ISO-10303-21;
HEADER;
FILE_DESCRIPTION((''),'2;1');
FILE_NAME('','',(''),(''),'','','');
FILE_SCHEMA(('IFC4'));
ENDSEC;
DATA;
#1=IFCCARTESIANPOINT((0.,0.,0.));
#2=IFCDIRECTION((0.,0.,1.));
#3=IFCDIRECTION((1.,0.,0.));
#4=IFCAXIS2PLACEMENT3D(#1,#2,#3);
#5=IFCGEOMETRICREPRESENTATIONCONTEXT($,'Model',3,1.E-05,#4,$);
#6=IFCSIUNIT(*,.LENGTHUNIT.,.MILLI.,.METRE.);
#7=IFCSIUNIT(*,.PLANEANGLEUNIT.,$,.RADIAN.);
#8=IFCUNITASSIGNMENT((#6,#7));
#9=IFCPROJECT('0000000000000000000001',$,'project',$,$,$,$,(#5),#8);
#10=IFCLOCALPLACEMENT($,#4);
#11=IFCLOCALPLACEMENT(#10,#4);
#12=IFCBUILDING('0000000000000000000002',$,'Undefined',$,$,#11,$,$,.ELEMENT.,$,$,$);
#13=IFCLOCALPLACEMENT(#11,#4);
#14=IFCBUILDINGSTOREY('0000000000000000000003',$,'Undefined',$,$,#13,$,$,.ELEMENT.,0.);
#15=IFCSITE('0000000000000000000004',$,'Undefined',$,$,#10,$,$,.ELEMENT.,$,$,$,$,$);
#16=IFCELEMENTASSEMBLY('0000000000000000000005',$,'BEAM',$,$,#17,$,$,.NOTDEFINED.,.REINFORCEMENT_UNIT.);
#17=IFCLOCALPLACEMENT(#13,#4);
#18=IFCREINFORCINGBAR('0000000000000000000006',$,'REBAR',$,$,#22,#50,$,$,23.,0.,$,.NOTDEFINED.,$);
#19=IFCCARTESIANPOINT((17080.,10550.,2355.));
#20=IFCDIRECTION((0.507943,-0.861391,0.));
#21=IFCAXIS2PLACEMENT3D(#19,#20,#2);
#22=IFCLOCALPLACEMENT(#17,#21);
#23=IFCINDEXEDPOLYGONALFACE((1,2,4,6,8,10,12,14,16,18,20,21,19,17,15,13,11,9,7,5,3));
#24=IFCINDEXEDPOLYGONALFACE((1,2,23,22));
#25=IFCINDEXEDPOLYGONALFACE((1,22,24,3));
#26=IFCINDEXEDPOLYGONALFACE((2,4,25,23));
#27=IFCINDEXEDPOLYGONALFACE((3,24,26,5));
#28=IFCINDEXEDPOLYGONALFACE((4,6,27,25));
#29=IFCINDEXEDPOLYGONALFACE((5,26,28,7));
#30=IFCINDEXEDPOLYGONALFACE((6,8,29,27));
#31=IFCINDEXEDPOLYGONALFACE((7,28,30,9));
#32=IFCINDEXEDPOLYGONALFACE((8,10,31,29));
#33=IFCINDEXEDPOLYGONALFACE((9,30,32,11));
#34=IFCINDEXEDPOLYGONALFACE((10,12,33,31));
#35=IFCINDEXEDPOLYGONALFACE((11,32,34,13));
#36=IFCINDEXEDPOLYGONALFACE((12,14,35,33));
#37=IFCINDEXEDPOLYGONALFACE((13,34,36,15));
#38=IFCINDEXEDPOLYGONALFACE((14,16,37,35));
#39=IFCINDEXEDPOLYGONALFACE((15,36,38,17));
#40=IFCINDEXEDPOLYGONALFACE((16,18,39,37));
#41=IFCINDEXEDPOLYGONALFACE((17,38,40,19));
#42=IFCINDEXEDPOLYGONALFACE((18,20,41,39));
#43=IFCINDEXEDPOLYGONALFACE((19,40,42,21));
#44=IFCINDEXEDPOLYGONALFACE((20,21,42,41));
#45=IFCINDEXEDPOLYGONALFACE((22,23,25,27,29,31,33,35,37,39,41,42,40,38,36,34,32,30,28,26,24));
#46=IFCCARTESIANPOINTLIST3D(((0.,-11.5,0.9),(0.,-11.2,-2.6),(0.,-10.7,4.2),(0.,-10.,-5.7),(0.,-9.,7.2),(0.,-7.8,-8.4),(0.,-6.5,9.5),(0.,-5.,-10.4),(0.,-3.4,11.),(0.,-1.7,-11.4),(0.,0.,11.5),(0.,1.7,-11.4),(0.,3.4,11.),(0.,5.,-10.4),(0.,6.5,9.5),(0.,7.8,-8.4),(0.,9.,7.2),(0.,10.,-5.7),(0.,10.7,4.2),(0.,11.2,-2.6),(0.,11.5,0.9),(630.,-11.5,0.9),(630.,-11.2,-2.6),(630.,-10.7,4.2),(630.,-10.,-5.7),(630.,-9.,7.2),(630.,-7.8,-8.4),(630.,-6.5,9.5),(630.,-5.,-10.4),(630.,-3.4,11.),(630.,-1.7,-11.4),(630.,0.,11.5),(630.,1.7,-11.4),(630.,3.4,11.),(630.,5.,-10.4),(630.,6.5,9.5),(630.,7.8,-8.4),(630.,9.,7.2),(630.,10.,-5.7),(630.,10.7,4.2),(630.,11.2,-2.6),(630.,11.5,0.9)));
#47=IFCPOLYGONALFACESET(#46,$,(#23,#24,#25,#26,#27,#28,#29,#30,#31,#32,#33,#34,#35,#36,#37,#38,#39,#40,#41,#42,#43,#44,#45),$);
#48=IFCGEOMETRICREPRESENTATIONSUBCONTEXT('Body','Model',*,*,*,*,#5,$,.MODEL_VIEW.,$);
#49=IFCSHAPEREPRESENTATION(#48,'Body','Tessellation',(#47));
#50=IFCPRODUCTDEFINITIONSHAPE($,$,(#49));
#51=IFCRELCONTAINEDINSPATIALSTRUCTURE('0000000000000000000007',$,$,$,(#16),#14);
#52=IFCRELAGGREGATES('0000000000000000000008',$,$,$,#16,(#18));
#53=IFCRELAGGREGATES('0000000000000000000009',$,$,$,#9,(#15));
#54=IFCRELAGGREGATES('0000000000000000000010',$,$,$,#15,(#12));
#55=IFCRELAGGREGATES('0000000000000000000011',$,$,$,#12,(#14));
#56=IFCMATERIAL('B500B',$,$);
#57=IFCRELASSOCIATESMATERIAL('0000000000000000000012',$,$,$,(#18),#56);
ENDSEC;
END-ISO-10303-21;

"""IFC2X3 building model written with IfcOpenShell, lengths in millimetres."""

from ifc_helpers import new_model, entity, si_unit, frame, origin_with_axes, place, context, subcontext, project, spatial, source, transform, mapped, material, element, aggregate, save


model = new_model("IFC2X3")

# Units and contexts
model_context = context("Model", 3, precision=1e-05, world=origin_with_axes())
body_context = subcontext(model_context, "Body", "Model", "MODEL_VIEW")
ifc_project = project(units=[si_unit("LENGTHUNIT", "METRE", prefix="MILLI"), si_unit("PLANEANGLEUNIT", "RADIAN")], contexts=[model_context])

# Site, building, storey
site_placement = place(None, origin_with_axes())
site = spatial("IfcSite", under=ifc_project, at=site_placement, Name="Undefined", CompositionType="ELEMENT")
building_placement = place(site_placement, origin_with_axes())
building = spatial("IfcBuilding", under=site, at=building_placement, Name="Undefined", CompositionType="ELEMENT")
storey_placement = place(building_placement, origin_with_axes())
storey = spatial("IfcBuildingStorey", under=building, at=storey_placement, Name="Undefined", CompositionType="ELEMENT", Elevation=0.0)

# Element assembly
assembly_1_placement = place(storey_placement, origin_with_axes())
assembly_1 = element("IfcElementAssembly", 1, at=assembly_1_placement, inside=storey, Name="BEAM", AssemblyPlace="NOTDEFINED", PredefinedType="REINFORCEMENT_UNIT")

# Shared definitions
ifc_material_1 = material(Name="B500B")

# Reinforcing bar
shared_shape_1 = source(origin_with_axes(), body_context, "Body", "AdvancedSweptSolid", [
    entity("IfcSweptDiskSolid", entity("IfcTrimmedCurve", entity("IfcLine", entity("IfcCartesianPoint", [0.0, 0.0, 0.0]), entity("IfcVector", entity("IfcDirection", [1.0, 0.0, 0.0]), 1.0)), [entity("IfcParameterValue", 0.0)], [entity("IfcParameterValue", 630.0)], True, "PARAMETER"), 11.5, None, 0.0, 630.0),
])
reinforcing_bar_1_placement = place(assembly_1_placement, frame((17080.0, 10550.0, 2355.0), z_axis=(0.507943, -0.861391, 0.0), x_axis=(0.0, 0.0, 1.0)))
reinforcing_bar_1 = element("IfcReinforcingBar", 2, at=reinforcing_bar_1_placement, material=ifc_material_1, Name="REBAR", BarRole="NOTDEFINED", CrossSectionArea=0.0, NominalDiameter=23.0, context=body_context, shape_type="MappedRepresentation", body=[
    mapped(shared_shape_1, transform((0.0, 0.0, 0.0))),
])
aggregate(assembly_1, [reinforcing_bar_1])

save(model, "model.ifc")
